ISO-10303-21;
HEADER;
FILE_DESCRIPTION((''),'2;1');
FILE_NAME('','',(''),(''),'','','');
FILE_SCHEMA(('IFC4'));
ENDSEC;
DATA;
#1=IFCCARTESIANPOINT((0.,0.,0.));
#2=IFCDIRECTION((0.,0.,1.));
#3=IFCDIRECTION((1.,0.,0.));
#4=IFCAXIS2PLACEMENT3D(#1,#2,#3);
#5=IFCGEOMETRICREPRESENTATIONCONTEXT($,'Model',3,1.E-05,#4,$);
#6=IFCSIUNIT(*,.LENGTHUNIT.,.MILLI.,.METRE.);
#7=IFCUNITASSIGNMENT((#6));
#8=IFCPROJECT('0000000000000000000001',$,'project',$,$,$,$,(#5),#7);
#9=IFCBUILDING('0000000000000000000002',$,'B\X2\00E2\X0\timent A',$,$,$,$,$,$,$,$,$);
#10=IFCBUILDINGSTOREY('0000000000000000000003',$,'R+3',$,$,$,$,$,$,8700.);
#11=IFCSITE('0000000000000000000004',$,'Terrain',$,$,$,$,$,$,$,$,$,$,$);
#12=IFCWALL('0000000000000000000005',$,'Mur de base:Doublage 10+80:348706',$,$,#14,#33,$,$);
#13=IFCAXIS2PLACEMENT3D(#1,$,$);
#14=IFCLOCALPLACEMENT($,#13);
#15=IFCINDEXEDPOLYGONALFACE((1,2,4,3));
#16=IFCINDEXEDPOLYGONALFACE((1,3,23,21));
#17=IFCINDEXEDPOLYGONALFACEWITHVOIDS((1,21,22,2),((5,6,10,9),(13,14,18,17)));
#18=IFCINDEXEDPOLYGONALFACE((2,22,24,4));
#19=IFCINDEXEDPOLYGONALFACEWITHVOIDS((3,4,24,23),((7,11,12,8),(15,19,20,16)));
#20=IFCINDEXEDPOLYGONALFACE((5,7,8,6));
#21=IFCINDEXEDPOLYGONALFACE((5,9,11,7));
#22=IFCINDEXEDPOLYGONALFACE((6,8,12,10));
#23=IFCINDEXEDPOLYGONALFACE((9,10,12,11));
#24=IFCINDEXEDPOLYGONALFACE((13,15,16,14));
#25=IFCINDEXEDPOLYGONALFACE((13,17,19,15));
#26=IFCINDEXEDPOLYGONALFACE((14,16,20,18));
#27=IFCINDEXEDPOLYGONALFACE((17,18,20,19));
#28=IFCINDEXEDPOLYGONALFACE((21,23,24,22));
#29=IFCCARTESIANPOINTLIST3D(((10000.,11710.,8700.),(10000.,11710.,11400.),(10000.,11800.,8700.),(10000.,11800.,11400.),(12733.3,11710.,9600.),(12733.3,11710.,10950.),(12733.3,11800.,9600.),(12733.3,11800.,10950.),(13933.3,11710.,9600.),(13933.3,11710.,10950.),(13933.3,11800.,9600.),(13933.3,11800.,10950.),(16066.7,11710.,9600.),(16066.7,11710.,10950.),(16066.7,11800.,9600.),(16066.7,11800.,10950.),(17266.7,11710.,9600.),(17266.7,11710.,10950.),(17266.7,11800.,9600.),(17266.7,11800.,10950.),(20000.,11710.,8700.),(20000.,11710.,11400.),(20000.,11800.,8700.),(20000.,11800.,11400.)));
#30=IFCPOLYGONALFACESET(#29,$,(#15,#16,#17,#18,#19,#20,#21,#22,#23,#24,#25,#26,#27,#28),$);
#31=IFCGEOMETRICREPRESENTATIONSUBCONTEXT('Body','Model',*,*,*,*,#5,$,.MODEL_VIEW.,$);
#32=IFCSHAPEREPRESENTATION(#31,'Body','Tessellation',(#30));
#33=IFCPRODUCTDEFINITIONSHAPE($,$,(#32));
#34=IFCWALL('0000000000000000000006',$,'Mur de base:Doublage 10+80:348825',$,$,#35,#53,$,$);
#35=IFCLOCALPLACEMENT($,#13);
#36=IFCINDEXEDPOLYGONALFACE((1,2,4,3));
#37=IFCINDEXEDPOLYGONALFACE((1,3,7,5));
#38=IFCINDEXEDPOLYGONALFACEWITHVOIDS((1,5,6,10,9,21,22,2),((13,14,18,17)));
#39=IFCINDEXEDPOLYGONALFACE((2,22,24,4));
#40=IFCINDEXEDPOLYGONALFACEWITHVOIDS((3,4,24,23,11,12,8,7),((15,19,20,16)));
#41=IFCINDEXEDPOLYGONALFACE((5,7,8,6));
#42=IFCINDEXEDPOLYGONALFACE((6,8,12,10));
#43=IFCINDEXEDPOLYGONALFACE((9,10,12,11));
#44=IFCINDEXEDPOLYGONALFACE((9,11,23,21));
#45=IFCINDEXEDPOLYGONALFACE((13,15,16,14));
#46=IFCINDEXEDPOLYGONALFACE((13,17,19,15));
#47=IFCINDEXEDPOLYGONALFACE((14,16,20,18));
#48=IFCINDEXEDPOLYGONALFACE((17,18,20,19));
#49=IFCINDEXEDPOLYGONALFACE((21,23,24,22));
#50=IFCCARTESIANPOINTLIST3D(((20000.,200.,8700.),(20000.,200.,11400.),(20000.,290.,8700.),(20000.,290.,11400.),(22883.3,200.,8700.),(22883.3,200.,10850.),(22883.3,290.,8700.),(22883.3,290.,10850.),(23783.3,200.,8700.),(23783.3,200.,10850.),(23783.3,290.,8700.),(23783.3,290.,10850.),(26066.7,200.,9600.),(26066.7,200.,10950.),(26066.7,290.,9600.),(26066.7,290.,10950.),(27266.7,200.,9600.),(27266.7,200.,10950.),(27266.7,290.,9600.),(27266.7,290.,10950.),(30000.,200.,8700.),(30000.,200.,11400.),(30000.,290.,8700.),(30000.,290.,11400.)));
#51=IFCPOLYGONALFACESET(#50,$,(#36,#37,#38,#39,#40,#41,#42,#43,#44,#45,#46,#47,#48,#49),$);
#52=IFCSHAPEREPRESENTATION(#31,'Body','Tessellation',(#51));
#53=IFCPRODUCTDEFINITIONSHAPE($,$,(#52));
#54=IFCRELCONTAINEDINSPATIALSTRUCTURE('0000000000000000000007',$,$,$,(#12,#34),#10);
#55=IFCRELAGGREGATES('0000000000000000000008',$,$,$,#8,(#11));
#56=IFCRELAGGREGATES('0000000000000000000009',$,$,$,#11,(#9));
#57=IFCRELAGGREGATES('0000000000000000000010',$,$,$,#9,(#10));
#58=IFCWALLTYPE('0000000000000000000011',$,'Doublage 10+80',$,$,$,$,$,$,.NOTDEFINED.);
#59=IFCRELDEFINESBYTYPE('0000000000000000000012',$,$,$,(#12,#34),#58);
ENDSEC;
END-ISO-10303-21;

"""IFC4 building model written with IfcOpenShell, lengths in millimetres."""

from ifc_helpers import new_model, si_unit, frame, frame_2d, origin_with_axes, place, context, subcontext, project, spatial, rectangle, extrude, type_object, element, save


model = new_model("IFC4")

# Units and contexts
model_context = context("Model", 3, precision=1e-05, world=origin_with_axes())
body_context = subcontext(model_context, "Body", "Model", "MODEL_VIEW")
ifc_project = project(units=[si_unit("LENGTHUNIT", "METRE", prefix="MILLI")], contexts=[model_context])

# Site, building, storey
site = spatial("IfcSite", under=ifc_project, Name="Terrain")
building = spatial("IfcBuilding", under=site, Name="Bâtiment A")
storey = spatial("IfcBuildingStorey", under=building, Name="R+3", Elevation=8700.0)

# Walls, openings
wall_type_1 = type_object("IfcWallType", Name="Doublage 10+80", PredefinedType="NOTDEFINED")
wall_1_placement = place(None, origin_with_axes())
wall_1 = element("IfcWall", 1, at=wall_1_placement, inside=storey, type_object=wall_type_1, Name="Mur de base:Doublage 10+80:348706", context=body_context, shape_type="SweptSolid", body=[
    extrude(rectangle(XDim=10000.0, YDim=90.0, at=frame_2d((15000.0, 11755.0))), frame((0.0, 0.0, 8700.0), z_axis=(0.0, 0.0, 1.0), x_axis=(1.0, 0.0, 0.0)), (0.0, 0.0, 1.0), 2700.0),
])
opening_1_placement = place(None, origin_with_axes())
element("IfcOpeningElement", 2, at=opening_1_placement, cuts=wall_1, context=body_context, shape_type="SweptSolid", body=[
    extrude(rectangle(XDim=1200.0, YDim=210.0, at=frame_2d((13333.3, 11755.0))), frame((0.0, 0.0, 9600.0), z_axis=(0.0, 0.0, 1.0), x_axis=(1.0, 0.0, 0.0)), (0.0, 0.0, 1.0), 1350.0),
])
opening_2_placement = place(None, origin_with_axes())
element("IfcOpeningElement", 3, at=opening_2_placement, cuts=wall_1, context=body_context, shape_type="SweptSolid", body=[
    extrude(rectangle(XDim=1200.0, YDim=210.0, at=frame_2d((16666.7, 11755.0))), frame((0.0, 0.0, 9600.0), z_axis=(0.0, 0.0, 1.0), x_axis=(1.0, 0.0, 0.0)), (0.0, 0.0, 1.0), 1350.0),
])
wall_2_placement = place(None, origin_with_axes())
wall_2 = element("IfcWall", 4, at=wall_2_placement, inside=storey, type_object=wall_type_1, Name="Mur de base:Doublage 10+80:348825", context=body_context, shape_type="SweptSolid", body=[
    extrude(rectangle(XDim=10000.0, YDim=90.0, at=frame_2d((25000.0, 245.0))), frame((0.0, 0.0, 8700.0), z_axis=(0.0, 0.0, 1.0), x_axis=(1.0, 0.0, 0.0)), (0.0, 0.0, 1.0), 2700.0),
])
opening_3_placement = place(None, origin_with_axes())
element("IfcOpeningElement", 5, at=opening_3_placement, cuts=wall_2, context=body_context, shape_type="SweptSolid", body=[
    extrude(rectangle(XDim=900.0, YDim=210.0, at=frame_2d((23333.3, 245.0))), frame((0.0, 0.0, 8700.0), z_axis=(0.0, 0.0, 1.0), x_axis=(1.0, 0.0, 0.0)), (0.0, 0.0, 1.0), 2150.0),
])
opening_4_placement = place(None, origin_with_axes())
element("IfcOpeningElement", 6, at=opening_4_placement, cuts=wall_2, context=body_context, shape_type="SweptSolid", body=[
    extrude(rectangle(XDim=1200.0, YDim=210.0, at=frame_2d((26666.7, 245.0))), frame((0.0, 0.0, 9600.0), z_axis=(0.0, 0.0, 1.0), x_axis=(1.0, 0.0, 0.0)), (0.0, 0.0, 1.0), 1350.0),
])

save(model, "model.ifc")
